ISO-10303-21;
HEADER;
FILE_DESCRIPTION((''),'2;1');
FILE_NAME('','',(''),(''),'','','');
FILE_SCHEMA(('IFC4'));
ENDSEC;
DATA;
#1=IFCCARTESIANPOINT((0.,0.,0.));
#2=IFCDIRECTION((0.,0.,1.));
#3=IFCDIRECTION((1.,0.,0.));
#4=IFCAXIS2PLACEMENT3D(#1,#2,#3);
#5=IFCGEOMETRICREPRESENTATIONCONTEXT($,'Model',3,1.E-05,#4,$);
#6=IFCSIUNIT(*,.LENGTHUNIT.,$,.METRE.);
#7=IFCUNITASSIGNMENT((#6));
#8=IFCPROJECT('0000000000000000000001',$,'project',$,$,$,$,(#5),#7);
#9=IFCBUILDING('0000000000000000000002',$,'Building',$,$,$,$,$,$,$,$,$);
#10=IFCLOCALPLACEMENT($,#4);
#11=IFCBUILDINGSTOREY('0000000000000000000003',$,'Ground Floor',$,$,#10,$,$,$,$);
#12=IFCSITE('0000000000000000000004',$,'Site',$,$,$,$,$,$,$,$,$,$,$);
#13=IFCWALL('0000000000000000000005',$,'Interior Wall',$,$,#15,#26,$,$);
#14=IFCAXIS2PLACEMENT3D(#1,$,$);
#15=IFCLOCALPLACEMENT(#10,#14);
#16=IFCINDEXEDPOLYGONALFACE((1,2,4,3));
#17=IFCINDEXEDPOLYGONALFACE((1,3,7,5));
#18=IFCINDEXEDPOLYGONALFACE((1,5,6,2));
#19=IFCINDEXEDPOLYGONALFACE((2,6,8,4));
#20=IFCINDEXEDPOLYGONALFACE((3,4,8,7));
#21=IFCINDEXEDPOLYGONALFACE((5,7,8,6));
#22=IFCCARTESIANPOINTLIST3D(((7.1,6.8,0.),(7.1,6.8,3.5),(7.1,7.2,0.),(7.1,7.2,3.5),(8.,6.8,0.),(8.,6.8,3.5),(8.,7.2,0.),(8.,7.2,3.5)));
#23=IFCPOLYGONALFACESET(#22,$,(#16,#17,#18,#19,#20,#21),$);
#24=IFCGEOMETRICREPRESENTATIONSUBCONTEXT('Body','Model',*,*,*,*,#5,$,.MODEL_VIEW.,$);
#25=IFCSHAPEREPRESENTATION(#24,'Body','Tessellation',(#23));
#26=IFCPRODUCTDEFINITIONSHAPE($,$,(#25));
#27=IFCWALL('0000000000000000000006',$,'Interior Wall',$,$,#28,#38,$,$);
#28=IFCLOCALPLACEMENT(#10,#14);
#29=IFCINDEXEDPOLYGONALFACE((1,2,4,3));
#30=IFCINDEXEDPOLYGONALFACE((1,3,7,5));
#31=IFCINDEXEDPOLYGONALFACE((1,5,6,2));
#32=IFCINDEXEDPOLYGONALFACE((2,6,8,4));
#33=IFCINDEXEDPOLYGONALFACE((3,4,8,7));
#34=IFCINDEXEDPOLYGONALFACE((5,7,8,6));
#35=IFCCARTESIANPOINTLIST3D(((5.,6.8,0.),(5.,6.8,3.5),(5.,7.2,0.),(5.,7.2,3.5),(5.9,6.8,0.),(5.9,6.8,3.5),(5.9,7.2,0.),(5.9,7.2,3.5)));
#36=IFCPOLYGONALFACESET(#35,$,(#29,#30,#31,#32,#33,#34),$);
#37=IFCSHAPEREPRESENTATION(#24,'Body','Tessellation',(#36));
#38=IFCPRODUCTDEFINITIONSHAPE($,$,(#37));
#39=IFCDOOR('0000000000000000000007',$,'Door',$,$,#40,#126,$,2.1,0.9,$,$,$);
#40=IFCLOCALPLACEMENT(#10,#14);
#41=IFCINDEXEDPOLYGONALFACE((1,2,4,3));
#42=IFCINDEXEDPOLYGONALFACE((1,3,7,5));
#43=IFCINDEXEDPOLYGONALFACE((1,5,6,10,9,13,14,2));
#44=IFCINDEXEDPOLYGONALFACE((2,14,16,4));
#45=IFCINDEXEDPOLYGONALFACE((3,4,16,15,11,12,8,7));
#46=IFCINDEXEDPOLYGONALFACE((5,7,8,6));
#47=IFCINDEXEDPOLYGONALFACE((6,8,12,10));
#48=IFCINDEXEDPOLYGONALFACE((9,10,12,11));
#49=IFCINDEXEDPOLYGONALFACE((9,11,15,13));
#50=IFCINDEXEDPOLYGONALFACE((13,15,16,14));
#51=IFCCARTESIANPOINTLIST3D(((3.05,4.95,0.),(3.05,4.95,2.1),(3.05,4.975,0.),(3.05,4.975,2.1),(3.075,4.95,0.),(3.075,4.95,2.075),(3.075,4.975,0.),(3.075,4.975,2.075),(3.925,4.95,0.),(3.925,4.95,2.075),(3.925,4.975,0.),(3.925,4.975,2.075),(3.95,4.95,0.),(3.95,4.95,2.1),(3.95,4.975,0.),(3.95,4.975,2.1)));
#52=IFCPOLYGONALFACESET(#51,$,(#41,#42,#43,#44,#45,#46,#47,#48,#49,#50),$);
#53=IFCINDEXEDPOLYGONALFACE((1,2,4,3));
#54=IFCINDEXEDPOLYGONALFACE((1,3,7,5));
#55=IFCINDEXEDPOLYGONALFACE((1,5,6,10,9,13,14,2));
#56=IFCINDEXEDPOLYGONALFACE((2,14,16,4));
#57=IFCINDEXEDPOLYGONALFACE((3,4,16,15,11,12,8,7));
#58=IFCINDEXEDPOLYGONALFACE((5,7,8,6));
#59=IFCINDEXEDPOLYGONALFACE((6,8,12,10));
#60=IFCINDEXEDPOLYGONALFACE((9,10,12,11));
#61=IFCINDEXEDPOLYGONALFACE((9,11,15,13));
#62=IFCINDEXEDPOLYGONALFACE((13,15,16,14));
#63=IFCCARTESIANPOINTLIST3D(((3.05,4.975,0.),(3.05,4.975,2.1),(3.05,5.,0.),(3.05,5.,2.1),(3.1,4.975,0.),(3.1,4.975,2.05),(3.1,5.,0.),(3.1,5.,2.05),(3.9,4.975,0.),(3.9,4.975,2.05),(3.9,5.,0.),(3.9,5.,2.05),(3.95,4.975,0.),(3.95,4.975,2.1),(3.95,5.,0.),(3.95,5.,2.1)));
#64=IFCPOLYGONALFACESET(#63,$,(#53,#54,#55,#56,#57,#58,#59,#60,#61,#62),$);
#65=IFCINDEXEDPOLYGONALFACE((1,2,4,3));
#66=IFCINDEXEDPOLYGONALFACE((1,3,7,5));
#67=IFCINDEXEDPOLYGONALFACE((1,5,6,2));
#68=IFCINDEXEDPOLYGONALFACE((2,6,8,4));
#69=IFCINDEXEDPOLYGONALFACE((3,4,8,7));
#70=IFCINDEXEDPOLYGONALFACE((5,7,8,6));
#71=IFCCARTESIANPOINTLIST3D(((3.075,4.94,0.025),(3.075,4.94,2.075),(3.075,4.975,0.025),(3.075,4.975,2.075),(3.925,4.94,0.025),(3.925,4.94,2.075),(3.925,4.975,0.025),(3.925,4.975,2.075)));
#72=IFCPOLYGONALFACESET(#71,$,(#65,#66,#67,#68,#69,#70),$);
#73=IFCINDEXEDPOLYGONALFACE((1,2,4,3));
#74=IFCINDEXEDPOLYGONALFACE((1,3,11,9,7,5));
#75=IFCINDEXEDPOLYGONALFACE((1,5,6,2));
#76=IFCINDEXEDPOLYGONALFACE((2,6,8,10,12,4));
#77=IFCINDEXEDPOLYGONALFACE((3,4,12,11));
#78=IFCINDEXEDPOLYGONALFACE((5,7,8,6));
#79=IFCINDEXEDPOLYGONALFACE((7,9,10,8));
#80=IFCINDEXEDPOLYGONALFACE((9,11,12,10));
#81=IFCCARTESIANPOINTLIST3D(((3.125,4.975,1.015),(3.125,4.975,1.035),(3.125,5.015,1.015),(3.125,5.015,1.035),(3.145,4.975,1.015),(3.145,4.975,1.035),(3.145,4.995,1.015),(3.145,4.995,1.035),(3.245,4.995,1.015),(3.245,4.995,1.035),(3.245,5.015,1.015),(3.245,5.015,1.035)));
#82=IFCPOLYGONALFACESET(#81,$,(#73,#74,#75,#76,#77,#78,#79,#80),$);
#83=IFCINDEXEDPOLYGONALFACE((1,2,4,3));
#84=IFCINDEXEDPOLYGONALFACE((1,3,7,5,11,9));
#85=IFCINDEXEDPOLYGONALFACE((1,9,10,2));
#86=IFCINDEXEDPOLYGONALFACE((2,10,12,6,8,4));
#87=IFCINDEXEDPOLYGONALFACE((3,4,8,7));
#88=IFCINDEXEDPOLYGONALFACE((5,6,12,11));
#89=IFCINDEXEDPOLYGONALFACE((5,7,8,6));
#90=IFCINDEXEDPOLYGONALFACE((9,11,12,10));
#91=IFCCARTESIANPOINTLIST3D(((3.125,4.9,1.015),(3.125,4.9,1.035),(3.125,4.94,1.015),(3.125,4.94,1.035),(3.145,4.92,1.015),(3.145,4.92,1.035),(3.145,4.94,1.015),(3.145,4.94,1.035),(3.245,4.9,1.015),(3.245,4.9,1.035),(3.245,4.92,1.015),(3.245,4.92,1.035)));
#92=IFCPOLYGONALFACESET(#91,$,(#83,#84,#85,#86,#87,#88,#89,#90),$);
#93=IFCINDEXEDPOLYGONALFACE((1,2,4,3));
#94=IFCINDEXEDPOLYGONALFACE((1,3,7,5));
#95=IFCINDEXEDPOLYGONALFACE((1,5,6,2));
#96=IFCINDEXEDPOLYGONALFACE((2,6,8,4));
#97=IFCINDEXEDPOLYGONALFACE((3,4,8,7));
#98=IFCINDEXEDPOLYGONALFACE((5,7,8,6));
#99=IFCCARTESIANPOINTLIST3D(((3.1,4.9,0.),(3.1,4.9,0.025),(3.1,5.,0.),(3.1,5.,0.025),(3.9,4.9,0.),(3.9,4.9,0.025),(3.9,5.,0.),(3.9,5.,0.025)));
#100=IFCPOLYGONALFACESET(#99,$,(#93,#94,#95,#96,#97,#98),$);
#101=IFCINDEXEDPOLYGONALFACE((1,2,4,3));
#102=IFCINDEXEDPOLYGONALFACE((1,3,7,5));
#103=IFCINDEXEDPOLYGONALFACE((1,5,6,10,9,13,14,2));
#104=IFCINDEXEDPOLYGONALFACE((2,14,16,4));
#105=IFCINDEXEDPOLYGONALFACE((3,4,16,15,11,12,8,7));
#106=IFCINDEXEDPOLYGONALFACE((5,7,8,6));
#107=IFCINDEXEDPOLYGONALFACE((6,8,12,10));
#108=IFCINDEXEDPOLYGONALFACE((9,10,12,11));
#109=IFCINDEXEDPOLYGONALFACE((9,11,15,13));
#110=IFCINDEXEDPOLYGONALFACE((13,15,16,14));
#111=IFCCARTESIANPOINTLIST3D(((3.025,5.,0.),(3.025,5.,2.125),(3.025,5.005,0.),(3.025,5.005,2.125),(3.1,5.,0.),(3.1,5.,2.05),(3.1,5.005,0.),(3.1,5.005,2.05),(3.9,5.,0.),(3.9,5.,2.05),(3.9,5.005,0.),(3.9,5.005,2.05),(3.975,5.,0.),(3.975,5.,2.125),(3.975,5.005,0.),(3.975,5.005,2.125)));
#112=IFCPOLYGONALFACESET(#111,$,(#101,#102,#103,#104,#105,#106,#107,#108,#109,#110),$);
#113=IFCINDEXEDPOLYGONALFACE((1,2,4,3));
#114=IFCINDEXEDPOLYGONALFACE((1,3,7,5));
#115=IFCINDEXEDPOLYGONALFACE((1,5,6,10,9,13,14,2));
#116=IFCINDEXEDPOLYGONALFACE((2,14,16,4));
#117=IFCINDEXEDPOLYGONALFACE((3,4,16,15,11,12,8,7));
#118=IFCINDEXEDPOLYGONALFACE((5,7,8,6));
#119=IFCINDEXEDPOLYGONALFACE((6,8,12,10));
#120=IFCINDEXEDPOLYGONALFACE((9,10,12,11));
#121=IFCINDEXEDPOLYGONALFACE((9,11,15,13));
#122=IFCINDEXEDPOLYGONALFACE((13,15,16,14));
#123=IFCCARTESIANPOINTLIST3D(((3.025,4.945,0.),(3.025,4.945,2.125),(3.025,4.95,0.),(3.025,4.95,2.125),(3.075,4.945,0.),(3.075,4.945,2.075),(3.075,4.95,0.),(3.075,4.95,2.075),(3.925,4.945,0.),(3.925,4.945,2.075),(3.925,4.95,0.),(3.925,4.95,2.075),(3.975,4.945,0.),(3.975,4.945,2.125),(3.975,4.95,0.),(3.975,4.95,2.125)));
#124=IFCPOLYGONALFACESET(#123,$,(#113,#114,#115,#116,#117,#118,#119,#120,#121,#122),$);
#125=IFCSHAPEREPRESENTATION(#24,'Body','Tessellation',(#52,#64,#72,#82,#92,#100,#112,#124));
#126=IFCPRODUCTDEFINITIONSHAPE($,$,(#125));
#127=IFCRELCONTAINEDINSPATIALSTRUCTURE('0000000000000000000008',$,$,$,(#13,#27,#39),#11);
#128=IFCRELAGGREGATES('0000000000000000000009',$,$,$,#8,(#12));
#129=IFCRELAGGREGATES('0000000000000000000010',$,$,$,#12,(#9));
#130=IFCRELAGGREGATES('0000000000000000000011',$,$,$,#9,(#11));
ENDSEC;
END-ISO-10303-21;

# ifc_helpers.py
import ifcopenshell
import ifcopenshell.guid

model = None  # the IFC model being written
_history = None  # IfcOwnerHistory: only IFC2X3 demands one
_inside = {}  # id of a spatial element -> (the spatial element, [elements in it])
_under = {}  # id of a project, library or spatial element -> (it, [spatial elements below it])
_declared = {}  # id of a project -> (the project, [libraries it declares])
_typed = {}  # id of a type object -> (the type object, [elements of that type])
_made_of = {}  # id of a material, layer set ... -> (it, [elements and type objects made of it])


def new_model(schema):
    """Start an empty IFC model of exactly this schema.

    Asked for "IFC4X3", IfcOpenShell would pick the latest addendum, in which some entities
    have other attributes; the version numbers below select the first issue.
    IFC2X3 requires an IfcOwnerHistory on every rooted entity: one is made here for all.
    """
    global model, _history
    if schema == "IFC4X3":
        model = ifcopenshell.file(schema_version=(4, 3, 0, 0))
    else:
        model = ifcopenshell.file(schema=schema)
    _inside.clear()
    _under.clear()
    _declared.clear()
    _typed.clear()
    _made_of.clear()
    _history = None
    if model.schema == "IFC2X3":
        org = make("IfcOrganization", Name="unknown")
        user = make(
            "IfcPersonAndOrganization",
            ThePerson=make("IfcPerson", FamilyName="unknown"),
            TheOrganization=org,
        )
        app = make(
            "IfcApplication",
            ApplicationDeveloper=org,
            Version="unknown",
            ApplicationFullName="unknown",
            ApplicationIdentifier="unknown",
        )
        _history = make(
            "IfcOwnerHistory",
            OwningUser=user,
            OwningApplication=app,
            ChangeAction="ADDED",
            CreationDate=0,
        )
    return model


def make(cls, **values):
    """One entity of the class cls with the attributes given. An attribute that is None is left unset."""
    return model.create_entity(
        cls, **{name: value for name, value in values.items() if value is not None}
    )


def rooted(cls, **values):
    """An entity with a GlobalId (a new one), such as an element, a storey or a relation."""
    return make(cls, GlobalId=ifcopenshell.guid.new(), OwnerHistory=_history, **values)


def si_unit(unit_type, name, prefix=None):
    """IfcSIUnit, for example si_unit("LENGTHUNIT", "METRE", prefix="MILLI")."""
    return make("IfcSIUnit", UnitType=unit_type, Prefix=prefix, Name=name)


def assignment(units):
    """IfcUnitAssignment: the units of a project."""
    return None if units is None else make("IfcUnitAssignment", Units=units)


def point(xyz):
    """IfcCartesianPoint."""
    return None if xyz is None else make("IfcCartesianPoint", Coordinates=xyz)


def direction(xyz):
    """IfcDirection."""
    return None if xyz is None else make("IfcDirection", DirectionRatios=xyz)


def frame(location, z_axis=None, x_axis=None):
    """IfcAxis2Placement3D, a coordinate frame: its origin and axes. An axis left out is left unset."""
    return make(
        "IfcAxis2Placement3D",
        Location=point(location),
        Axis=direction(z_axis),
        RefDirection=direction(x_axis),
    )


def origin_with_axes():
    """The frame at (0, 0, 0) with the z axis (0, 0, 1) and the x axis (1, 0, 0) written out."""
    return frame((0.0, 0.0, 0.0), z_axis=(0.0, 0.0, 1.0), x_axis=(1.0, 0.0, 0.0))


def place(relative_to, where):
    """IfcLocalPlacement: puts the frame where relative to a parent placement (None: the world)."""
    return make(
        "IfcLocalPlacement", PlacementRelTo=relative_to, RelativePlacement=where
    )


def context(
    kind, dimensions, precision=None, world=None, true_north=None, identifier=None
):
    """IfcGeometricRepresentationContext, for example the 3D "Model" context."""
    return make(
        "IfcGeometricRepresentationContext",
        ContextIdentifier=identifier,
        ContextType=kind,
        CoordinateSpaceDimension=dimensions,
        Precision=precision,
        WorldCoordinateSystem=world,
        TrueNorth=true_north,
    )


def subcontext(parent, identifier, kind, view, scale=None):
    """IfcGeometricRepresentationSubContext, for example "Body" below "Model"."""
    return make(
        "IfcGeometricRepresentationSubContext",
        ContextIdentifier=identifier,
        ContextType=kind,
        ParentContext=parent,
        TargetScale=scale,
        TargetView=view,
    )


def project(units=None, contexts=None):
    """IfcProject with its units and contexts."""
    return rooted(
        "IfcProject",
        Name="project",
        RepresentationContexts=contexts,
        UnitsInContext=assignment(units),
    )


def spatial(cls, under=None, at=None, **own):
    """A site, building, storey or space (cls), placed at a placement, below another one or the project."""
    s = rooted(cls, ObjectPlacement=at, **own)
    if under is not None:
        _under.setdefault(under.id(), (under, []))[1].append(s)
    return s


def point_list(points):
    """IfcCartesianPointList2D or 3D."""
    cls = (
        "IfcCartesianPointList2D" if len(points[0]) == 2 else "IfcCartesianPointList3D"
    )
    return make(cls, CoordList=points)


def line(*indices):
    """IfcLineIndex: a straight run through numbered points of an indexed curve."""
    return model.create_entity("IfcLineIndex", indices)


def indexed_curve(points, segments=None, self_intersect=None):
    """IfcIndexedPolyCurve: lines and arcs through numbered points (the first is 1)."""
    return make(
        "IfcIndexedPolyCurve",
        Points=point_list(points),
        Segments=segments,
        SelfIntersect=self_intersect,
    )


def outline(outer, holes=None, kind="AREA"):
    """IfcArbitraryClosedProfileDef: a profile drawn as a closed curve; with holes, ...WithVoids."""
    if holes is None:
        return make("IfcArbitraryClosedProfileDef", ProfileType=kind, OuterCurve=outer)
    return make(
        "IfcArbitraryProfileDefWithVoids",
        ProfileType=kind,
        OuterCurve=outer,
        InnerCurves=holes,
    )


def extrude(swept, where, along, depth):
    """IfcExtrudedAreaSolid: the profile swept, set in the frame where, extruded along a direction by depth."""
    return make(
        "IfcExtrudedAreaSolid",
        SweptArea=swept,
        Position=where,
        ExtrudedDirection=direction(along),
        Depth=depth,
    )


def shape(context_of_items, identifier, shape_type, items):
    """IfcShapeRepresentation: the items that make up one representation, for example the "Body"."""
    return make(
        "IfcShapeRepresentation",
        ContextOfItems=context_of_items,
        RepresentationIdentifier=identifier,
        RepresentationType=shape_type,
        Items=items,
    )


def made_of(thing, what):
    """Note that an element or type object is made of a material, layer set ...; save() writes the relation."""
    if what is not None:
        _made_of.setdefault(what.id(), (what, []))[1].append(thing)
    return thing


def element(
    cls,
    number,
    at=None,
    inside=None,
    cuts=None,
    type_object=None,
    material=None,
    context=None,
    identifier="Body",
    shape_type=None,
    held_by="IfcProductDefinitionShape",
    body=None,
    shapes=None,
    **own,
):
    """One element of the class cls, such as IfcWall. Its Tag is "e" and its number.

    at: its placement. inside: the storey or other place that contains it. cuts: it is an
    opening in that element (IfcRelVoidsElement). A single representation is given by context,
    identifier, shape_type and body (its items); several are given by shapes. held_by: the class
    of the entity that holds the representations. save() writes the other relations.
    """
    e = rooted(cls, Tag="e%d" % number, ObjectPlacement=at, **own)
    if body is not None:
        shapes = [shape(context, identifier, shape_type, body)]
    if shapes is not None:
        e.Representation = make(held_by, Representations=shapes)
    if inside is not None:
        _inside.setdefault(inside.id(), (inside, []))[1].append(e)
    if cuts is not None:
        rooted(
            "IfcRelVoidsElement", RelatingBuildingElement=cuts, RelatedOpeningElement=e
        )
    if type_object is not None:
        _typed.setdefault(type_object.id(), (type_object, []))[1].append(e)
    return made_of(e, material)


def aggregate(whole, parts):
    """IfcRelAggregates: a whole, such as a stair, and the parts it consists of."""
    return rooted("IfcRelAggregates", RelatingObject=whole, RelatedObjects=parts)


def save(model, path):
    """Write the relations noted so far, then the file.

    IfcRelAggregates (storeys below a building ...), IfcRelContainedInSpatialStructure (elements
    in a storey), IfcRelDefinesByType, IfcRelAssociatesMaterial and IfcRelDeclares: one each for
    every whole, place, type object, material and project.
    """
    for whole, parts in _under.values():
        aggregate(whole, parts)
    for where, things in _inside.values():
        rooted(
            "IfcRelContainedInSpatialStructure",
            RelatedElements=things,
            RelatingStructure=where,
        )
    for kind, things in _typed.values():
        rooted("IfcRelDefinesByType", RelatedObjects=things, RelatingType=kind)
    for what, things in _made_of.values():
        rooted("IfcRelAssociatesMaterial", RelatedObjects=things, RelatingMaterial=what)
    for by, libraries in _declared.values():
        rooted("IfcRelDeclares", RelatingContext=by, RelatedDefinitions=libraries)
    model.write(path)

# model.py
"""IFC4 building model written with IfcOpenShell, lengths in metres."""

from ifc_helpers import new_model, si_unit, frame, origin_with_axes, place, context, subcontext, project, spatial, line, indexed_curve, outline, extrude, element, save


model = new_model("IFC4")

# Units and contexts
model_context = context("Model", 3, precision=1e-05, world=origin_with_axes())
body_context = subcontext(model_context, "Body", "Model", "MODEL_VIEW")
ifc_project = project(units=[si_unit("LENGTHUNIT", "METRE")], contexts=[model_context])

# Site, building, storey
site = spatial("IfcSite", under=ifc_project, Name="Site")
building = spatial("IfcBuilding", under=site, Name="Building")
storey_placement = place(None, origin_with_axes())
storey = spatial("IfcBuildingStorey", under=building, at=storey_placement, Name="Ground Floor")

# Walls
for number, where, z_axis, x_axis, name in (
    (1, (8.0, 7.0, 0.0), (0.0, 0.0, 1.0), (-1.0, 0.0, 0.0), "Interior Wall"),
    (2, (5.9, 7.0, 0.0), (0.0, 0.0, 1.0), (-1.0, 0.0, 0.0), "Interior Wall"),
):
    element("IfcWall", number, at=place(storey_placement, frame(where, z_axis=z_axis, x_axis=x_axis)), inside=storey, Name=name, context=body_context, shape_type="SweptSolid", body=[
        extrude(outline(indexed_curve([(0.0, 0.0), (0.0, 0.4), (0.9, 0.4), (0.9, 0.0), (0.0, 0.0)], self_intersect=False)), frame((0.0, -0.2, 0.0), z_axis=(0.0, 0.0, 1.0), x_axis=(1.0, 0.0, 0.0)), (0.0, 0.0, 1.0), 3.5),
    ])

# Door
door_1_placement = place(storey_placement, frame((3.95, 5.0, 0.0), z_axis=(0.0, 0.0, 1.0), x_axis=(-1.0, 0.0, 0.0)))
element("IfcDoor", 3, at=door_1_placement, inside=storey, Name="Door", OverallHeight=2.1, OverallWidth=0.9, context=body_context, shape_type="SweptSolid", body=[
    extrude(outline(indexed_curve([(0.0, 0.0), (0.0, 2.1), (0.9, 2.1), (0.9, 0.0), (0.875, 0.0), (0.875, 2.075), (0.025, 2.075), (0.025, 0.0)], segments=[line(1, 2, 3, 4, 5, 6, 7, 8, 1)])), frame((0.0, 0.025, 0.0), z_axis=(0.0, -1.0, 0.0), x_axis=(1.0, 0.0, 0.0)), (0.0, 0.0, -1.0), 0.025),
    extrude(outline(indexed_curve([(0.0, 0.0), (0.0, 2.1), (0.9, 2.1), (0.9, 0.0), (0.85, 0.0), (0.85, 2.05), (0.05, 2.05), (0.05, 0.0)], segments=[line(1, 2, 3, 4, 5, 6, 7, 8, 1)])), frame((0.0, 0.0, 0.0), z_axis=(0.0, -1.0, 0.0), x_axis=(1.0, 0.0, 0.0)), (0.0, 0.0, -1.0), 0.025),
    extrude(outline(indexed_curve([(0.0, 0.0), (0.85, 0.0), (0.85, 0.035), (0.0, 0.035)], segments=[line(1, 2, 3, 4, 1)])), frame((0.025, 0.025, 0.025), z_axis=(0.0, 0.0, 1.0), x_axis=(1.0, 0.0, 0.0)), (0.0, 0.0, 1.0), 2.05),
    extrude(outline(indexed_curve([(0.0, 0.0), (0.0, -0.04), (-0.12, -0.04), (-0.12, -0.02), (-0.02, -0.02), (-0.02, 0.0)], segments=[line(1, 2, 3, 4, 5, 6, 1)])), frame((0.825, 0.025, 1.015), z_axis=(0.0, 0.0, 1.0), x_axis=(1.0, 0.0, 0.0)), (0.0, 0.0, 1.0), 0.02),
    extrude(outline(indexed_curve([(0.0, 0.0), (0.0, 0.04), (-0.12, 0.04), (-0.12, 0.02), (-0.02, 0.02), (-0.02, 0.0)], segments=[line(1, 2, 3, 4, 5, 6, 1)])), frame((0.825, 0.06, 1.015), z_axis=(0.0, 0.0, 1.0), x_axis=(1.0, 0.0, 0.0)), (0.0, 0.0, 1.0), 0.02),
    extrude(outline(indexed_curve([(0.0, 0.0), (0.8, 0.0), (0.8, 0.1), (0.0, 0.1)], segments=[line(1, 2, 3, 4, 1)])), frame((0.05, 0.0, 0.0), z_axis=(0.0, 0.0, 1.0), x_axis=(1.0, 0.0, 0.0)), (0.0, 0.0, 1.0), 0.025),
    extrude(outline(indexed_curve([(0.0, 0.0), (0.0, 2.125), (0.95, 2.125), (0.95, 0.0), (0.875, 0.0), (0.875, 2.05), (0.075, 2.05), (0.075, 0.0)], segments=[line(1, 2, 3, 4, 5, 6, 7, 8, 1)])), frame((-0.025, -0.005, 0.0), z_axis=(0.0, -1.0, 0.0), x_axis=(1.0, 0.0, 0.0)), (0.0, 0.0, -1.0), 0.005),
    extrude(outline(indexed_curve([(0.0, 0.0), (0.0, 2.125), (0.95, 2.125), (0.95, 0.0), (0.9, 0.0), (0.9, 2.075), (0.05, 2.075), (0.05, 0.0)], segments=[line(1, 2, 3, 4, 5, 6, 7, 8, 1)])), frame((-0.025, 0.05, 0.0), z_axis=(0.0, -1.0, 0.0), x_axis=(1.0, 0.0, 0.0)), (0.0, 0.0, -1.0), 0.005),
])

save(model, "model.ifc")
